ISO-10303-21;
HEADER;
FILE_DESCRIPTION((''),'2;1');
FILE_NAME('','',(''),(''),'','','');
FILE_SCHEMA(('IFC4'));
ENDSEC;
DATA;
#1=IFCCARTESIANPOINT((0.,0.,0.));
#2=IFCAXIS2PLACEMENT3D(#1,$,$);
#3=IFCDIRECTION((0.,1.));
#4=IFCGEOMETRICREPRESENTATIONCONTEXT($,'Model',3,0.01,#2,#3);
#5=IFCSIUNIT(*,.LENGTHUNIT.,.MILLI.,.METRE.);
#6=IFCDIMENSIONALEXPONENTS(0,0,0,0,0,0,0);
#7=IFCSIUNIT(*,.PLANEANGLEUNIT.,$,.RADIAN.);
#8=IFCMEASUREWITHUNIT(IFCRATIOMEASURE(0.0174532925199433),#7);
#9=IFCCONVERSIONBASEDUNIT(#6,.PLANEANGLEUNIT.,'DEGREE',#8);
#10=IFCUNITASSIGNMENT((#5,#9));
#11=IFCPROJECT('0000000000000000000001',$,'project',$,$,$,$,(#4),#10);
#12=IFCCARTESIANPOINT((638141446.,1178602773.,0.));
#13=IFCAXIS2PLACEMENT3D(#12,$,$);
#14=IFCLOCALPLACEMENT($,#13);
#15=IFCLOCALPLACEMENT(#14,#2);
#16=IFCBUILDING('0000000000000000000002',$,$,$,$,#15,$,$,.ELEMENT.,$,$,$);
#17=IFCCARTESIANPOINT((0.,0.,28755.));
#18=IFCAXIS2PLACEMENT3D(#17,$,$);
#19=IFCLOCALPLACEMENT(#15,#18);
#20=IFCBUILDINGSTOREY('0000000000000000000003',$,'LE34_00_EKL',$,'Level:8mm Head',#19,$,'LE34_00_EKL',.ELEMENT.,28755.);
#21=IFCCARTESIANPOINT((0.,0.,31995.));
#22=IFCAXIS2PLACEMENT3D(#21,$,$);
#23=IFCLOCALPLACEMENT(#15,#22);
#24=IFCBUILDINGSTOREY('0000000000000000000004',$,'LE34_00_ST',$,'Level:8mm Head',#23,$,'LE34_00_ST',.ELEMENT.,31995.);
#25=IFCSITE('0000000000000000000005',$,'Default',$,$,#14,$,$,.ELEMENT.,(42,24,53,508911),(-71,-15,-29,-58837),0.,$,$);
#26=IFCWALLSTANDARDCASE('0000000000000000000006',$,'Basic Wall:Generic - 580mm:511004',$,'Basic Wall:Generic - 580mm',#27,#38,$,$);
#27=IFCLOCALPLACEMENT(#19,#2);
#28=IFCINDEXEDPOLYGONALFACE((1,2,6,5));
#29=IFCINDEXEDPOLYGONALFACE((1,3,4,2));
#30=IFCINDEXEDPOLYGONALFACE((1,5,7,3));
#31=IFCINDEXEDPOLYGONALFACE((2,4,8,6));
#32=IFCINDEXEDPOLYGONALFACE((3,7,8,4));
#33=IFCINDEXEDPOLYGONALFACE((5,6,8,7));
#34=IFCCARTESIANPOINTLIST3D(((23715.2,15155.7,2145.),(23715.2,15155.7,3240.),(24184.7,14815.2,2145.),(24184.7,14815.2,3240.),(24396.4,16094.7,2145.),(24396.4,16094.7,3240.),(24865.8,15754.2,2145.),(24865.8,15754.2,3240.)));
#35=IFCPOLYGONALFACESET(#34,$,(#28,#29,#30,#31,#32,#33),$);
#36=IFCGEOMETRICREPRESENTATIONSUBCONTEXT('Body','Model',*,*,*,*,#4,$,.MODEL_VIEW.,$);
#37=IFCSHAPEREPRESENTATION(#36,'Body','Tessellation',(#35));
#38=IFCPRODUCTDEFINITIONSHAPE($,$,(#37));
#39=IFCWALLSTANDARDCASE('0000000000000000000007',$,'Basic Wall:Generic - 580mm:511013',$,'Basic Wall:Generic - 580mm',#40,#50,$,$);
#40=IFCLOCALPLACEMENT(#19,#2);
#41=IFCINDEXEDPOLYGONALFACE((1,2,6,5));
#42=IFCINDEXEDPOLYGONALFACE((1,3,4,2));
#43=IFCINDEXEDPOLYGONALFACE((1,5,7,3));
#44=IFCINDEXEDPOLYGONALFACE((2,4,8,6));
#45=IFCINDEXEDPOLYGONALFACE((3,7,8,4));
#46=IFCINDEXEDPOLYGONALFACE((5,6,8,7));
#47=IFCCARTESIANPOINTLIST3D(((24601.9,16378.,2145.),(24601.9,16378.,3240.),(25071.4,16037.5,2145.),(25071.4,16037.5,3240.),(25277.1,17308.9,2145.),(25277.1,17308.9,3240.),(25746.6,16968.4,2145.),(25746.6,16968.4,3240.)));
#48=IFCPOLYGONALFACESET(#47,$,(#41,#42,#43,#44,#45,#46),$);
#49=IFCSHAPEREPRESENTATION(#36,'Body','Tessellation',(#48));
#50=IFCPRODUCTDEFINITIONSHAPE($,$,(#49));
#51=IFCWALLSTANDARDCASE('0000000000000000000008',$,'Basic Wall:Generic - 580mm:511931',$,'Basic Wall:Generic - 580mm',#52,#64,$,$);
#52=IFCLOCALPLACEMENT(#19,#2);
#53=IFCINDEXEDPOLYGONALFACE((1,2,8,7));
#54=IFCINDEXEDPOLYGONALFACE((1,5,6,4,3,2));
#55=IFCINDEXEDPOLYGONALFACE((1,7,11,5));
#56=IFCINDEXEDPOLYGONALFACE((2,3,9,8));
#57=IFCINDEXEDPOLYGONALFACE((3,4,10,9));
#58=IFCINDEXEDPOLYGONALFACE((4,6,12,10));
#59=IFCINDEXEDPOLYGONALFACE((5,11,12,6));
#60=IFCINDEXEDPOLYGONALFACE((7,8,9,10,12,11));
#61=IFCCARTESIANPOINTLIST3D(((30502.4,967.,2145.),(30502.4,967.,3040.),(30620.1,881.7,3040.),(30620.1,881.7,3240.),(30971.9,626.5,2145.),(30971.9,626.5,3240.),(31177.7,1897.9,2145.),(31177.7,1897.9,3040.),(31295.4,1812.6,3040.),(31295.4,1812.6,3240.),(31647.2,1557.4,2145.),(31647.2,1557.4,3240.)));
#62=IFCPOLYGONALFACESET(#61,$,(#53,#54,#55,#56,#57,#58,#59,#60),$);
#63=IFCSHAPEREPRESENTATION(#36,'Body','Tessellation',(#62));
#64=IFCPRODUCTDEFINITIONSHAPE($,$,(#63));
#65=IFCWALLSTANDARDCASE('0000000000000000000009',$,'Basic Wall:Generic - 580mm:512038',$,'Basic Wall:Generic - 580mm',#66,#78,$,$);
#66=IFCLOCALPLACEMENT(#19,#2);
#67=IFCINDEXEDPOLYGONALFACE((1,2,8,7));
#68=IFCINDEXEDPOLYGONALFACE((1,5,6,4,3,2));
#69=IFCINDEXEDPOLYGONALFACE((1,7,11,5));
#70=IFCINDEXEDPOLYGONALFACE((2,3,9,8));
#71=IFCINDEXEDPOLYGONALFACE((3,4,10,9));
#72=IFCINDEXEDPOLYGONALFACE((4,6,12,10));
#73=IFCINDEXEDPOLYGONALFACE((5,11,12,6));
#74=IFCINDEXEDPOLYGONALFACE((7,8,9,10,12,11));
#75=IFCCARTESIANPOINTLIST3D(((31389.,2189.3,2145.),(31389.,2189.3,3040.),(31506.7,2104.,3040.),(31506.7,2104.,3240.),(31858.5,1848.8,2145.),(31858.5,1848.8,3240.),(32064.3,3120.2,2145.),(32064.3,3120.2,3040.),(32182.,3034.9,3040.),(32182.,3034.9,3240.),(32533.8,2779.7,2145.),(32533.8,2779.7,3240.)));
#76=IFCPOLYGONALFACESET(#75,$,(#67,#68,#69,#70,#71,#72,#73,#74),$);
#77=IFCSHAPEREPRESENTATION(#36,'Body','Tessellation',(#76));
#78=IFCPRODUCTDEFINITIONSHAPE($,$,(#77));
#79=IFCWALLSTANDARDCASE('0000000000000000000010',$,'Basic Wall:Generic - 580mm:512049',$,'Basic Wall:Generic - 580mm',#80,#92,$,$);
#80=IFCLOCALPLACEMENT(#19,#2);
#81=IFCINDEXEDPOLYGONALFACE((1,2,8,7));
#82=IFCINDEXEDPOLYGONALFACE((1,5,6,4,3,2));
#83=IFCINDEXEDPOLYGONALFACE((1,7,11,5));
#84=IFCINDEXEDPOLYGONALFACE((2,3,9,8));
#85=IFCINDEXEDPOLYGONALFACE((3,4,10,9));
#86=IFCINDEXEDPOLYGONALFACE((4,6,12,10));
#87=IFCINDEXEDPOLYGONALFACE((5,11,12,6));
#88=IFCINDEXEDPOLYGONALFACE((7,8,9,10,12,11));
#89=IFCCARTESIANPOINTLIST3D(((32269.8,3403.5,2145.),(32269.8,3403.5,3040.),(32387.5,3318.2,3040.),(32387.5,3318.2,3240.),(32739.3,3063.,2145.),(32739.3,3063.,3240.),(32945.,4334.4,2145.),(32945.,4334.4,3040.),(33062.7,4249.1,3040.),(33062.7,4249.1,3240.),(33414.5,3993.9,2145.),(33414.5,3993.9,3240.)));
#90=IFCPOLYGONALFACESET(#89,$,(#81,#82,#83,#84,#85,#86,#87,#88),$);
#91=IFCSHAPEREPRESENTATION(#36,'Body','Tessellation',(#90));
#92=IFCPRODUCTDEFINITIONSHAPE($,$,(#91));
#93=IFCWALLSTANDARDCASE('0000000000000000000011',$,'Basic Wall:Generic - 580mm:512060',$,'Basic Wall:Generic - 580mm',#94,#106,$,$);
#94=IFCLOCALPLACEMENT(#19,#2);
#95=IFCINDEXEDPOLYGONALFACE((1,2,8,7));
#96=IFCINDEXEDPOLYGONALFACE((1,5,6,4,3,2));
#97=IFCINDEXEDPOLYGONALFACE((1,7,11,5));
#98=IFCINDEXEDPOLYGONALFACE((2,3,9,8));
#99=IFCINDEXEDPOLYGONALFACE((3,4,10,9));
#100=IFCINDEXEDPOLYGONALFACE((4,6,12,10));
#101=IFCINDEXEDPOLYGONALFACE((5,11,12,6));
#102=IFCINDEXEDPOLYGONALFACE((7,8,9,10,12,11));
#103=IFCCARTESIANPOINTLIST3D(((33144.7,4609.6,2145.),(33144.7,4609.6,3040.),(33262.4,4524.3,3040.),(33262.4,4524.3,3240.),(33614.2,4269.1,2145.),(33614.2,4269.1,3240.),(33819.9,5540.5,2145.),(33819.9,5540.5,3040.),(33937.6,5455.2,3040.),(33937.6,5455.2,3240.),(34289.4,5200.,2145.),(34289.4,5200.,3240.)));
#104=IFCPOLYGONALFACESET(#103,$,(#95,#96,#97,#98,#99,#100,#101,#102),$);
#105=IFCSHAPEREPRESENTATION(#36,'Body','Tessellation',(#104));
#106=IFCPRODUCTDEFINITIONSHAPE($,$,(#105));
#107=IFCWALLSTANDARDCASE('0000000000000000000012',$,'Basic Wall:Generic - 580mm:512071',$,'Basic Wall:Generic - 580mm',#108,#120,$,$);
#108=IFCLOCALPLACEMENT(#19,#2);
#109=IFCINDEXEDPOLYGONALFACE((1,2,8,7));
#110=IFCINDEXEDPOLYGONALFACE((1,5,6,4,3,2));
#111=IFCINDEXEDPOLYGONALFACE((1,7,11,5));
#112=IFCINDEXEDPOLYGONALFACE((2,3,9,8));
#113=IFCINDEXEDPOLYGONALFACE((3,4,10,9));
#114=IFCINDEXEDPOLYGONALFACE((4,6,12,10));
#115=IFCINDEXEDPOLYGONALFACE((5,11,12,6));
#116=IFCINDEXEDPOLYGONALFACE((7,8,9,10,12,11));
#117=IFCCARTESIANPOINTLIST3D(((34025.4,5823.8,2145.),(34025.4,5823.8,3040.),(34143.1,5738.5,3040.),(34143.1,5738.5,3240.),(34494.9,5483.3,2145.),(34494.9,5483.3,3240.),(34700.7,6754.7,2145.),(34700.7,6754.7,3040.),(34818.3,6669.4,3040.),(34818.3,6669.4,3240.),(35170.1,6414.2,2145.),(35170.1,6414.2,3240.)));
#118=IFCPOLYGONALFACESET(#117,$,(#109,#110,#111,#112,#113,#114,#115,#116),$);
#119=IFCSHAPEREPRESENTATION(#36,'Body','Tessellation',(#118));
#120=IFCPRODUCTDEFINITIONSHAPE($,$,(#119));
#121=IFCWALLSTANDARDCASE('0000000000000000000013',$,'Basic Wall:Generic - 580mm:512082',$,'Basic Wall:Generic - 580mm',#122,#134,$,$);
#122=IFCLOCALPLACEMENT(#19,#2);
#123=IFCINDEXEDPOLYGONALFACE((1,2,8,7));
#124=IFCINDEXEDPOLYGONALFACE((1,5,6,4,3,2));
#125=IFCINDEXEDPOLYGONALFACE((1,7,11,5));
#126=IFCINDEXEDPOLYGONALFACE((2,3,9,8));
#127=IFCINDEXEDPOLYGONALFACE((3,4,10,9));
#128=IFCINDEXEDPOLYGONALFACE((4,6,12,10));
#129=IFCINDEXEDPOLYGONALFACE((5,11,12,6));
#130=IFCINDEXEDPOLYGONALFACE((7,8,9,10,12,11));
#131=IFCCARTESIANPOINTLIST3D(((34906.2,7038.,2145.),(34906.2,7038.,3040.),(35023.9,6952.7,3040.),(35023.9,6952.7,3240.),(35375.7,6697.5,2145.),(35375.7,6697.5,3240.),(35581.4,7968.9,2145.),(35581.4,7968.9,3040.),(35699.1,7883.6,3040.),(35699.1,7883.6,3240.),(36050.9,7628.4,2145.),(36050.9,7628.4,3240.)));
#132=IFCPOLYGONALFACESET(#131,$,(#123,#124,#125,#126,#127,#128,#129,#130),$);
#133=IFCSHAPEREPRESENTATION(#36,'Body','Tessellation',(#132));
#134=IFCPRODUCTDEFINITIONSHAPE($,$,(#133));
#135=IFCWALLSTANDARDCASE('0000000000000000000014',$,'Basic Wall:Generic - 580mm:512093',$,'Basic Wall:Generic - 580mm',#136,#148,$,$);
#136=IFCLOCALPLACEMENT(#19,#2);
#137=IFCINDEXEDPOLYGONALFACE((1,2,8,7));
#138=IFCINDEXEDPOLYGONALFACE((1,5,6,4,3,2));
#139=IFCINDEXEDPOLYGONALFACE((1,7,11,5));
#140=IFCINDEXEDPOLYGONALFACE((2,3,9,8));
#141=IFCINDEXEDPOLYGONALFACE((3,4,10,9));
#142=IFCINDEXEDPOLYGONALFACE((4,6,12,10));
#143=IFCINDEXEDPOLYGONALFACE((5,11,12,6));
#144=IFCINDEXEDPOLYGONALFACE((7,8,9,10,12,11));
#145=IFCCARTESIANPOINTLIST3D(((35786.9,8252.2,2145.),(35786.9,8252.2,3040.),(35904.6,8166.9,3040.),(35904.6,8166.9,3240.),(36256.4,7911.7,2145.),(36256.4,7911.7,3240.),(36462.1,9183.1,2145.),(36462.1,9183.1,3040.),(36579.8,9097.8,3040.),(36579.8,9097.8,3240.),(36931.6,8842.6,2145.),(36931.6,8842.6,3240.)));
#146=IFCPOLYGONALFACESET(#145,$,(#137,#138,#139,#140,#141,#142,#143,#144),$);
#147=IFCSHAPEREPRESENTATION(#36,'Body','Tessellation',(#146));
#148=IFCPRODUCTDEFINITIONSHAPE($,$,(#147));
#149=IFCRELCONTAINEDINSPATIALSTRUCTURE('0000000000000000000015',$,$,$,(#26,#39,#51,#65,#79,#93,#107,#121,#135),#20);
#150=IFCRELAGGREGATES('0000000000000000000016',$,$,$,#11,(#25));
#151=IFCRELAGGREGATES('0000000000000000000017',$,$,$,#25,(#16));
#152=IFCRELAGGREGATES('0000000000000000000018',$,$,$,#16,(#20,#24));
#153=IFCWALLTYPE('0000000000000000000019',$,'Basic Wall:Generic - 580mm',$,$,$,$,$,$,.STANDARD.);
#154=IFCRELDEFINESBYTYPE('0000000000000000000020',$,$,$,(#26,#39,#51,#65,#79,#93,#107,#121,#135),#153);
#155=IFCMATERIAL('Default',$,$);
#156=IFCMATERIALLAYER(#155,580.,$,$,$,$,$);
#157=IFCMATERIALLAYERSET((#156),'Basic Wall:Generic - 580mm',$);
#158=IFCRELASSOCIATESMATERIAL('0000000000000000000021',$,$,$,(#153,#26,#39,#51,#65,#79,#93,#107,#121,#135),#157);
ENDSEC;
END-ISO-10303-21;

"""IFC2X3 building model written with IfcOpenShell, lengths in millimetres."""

from ifc_helpers import new_model, entity, si_unit, converted_unit, direction, frame, frame_2d, origin, place, context, subcontext, project, spatial, polyline, rectangle, extrude, clip, bounded_halfspace, material, layer, layer_set, layer_usage, type_object, element, save


model = new_model("IFC2X3")

# Units and contexts
model_context = context("Model", 3, precision=0.01, world=origin(), true_north=direction((0.0, 1.0)))
body_context = subcontext(model_context, "Body", "Model", "MODEL_VIEW")
ifc_project = project(units=[si_unit("LENGTHUNIT", "METRE", prefix="MILLI"), converted_unit("PLANEANGLEUNIT", "DEGREE", entity("IfcRatioMeasure", 0.0174532925199433), si_unit("PLANEANGLEUNIT", "RADIAN"), dimensions=[0, 0, 0, 0, 0, 0, 0])], contexts=[model_context])

# Site, building, storey
site_placement = place(None, frame((638141446.0, 1178602773.0, 0.0)))
site = spatial("IfcSite", under=ifc_project, at=site_placement, Name="Default", CompositionType="ELEMENT", RefLatitude=(42, 24, 53, 508911), RefLongitude=(-71, -15, -29, -58837), RefElevation=0.0)
building_placement = place(site_placement, origin())
building = spatial("IfcBuilding", under=site, at=building_placement, CompositionType="ELEMENT")
storey_1_placement = place(building_placement, frame((0.0, 0.0, 28755.0)))
storey_1 = spatial("IfcBuildingStorey", under=building, at=storey_1_placement, Name="LE34_00_EKL", ObjectType="Level:8mm Head", LongName="LE34_00_EKL", CompositionType="ELEMENT", Elevation=28755.0)

# Shared definitions
ifc_material_1 = material(Name="Default")

# Shared definitions
storey_2_placement = place(building_placement, frame((0.0, 0.0, 31995.0)))
storey_2 = spatial("IfcBuildingStorey", under=building, at=storey_2_placement, Name="LE34_00_ST", ObjectType="Level:8mm Head", LongName="LE34_00_ST", CompositionType="ELEMENT", Elevation=31995.0)

# Walls
ifc_layer_1 = layer(ifc_material_1, 580.0)
ifc_layer_set_1 = layer_set([ifc_layer_1], Name="Basic Wall:Generic - 580mm")
wall_type_1 = type_object("IfcWallType", Name="Basic Wall:Generic - 580mm", PredefinedType="STANDARD", material=ifc_layer_set_1)
ifc_layer_usage_1 = layer_usage(ifc_layer_set_1, "AXIS2", "NEGATIVE", 290.0)
wall_1_placement = place(storey_1_placement, frame((23950.0, 14985.5, 2145.0), z_axis=(0.0, 0.0, 1.0), x_axis=(0.587164, 0.809468, 0.0)))
element("IfcWallStandardCase", 1, at=wall_1_placement, inside=storey_1, type_object=wall_type_1, material=ifc_layer_usage_1, Name="Basic Wall:Generic - 580mm:511004", ObjectType="Basic Wall:Generic - 580mm", context=body_context, shape_type="SweptSolid", body=[
    extrude(rectangle(XDim=1160.0, YDim=580.0, at=frame_2d((580.0, 0.0), x_axis=(-1.0, 0.0))), origin(), (0.0, 0.0, 1.0), 1095.0),
])
ifc_layer_usage_2 = layer_usage(ifc_layer_set_1, "AXIS2", "NEGATIVE", 290.0)
wall_2_placement = place(storey_1_placement, frame((24836.6, 16207.8, 2145.0), z_axis=(0.0, 0.0, 1.0), x_axis=(0.587164, 0.809468, 0.0)))
element("IfcWallStandardCase", 2, at=wall_2_placement, inside=storey_1, type_object=wall_type_1, material=ifc_layer_usage_2, Name="Basic Wall:Generic - 580mm:511013", ObjectType="Basic Wall:Generic - 580mm", context=body_context, shape_type="SweptSolid", body=[
    extrude(rectangle(XDim=1150.0, YDim=580.0, at=frame_2d((575.0, 0.0), x_axis=(-1.0, 0.0))), origin(), (0.0, 0.0, 1.0), 1095.0),
])
ifc_layer_usage_3 = layer_usage(ifc_layer_set_1, "AXIS2", "NEGATIVE", 290.0)
wall_3_placement = place(storey_1_placement, frame((30737.2, 796.8, 2145.0), z_axis=(0.0, 0.0, 1.0), x_axis=(0.587164, 0.809468, 0.0)))
element("IfcWallStandardCase", 3, at=wall_3_placement, inside=storey_1, type_object=wall_type_1, material=ifc_layer_usage_3, Name="Basic Wall:Generic - 580mm:511931", ObjectType="Basic Wall:Generic - 580mm", context=body_context, shape_type="Clipping", body=[
    clip(clip(extrude(rectangle(XDim=1150.0, YDim=580.0, at=frame_2d((575.0, 0.0), x_axis=(-1.0, 0.0))), origin(), (0.0, 0.0, 1.0), 1095.0), bounded_halfspace(frame((0.0, 144.6, 895.0), z_axis=(0.0, 0.0, -1.0), x_axis=(0.0, 1.0, 0.0)), True, frame((0.0, 144.6, 895.0), z_axis=(0.0, 0.0, -1.0), x_axis=(0.0, 1.0, 0.0)), polyline([(0.0, 0.0), (145.4, 0.0), (145.4, 1150.0), (0.0, 1150.0), (0.0, 0.0)]))), bounded_halfspace(frame((1150.0, 144.6, 895.0), z_axis=(0.0, -1.0, 0.0), x_axis=(0.0, 0.0, 1.0)), True, frame((1150.0, 144.6, 895.0), z_axis=(0.0, -1.0, 0.0), x_axis=(0.0, 0.0, 1.0)), polyline([(0.0, 0.0), (200.0, 0.0), (200.0, 1150.0), (0.0, 1150.0), (0.0, 0.0)]))),
])
ifc_layer_usage_4 = layer_usage(ifc_layer_set_1, "AXIS2", "NEGATIVE", 290.0)
wall_4_placement = place(storey_1_placement, frame((31623.8, 2019.1, 2145.0), z_axis=(0.0, 0.0, 1.0), x_axis=(0.587164, 0.809468, 0.0)))
element("IfcWallStandardCase", 4, at=wall_4_placement, inside=storey_1, type_object=wall_type_1, material=ifc_layer_usage_4, Name="Basic Wall:Generic - 580mm:512038", ObjectType="Basic Wall:Generic - 580mm", context=body_context, shape_type="Clipping", body=[
    clip(clip(extrude(rectangle(XDim=1150.0, YDim=580.0, at=frame_2d((575.0, 0.0), x_axis=(-1.0, 0.0))), origin(), (0.0, 0.0, 1.0), 1095.0), bounded_halfspace(frame((0.0, 144.6, 895.0), z_axis=(0.0, 0.0, -1.0), x_axis=(0.0, 1.0, 0.0)), True, frame((0.0, 144.6, 895.0), z_axis=(0.0, 0.0, -1.0), x_axis=(0.0, 1.0, 0.0)), polyline([(0.0, 0.0), (145.4, 0.0), (145.4, 1150.0), (0.0, 1150.0), (0.0, 0.0)]))), bounded_halfspace(frame((1150.0, 144.6, 895.0), z_axis=(0.0, -1.0, 0.0), x_axis=(0.0, 0.0, 1.0)), True, frame((1150.0, 144.6, 895.0), z_axis=(0.0, -1.0, 0.0), x_axis=(0.0, 0.0, 1.0)), polyline([(0.0, 0.0), (200.0, 0.0), (200.0, 1150.0), (0.0, 1150.0), (0.0, 0.0)]))),
])
ifc_layer_usage_5 = layer_usage(ifc_layer_set_1, "AXIS2", "NEGATIVE", 290.0)
wall_5_placement = place(storey_1_placement, frame((32504.5, 3233.3, 2145.0), z_axis=(0.0, 0.0, 1.0), x_axis=(0.587164, 0.809468, 0.0)))
element("IfcWallStandardCase", 5, at=wall_5_placement, inside=storey_1, type_object=wall_type_1, material=ifc_layer_usage_5, Name="Basic Wall:Generic - 580mm:512049", ObjectType="Basic Wall:Generic - 580mm", context=body_context, shape_type="Clipping", body=[
    clip(clip(extrude(rectangle(XDim=1150.0, YDim=580.0, at=frame_2d((575.0, 0.0), x_axis=(-1.0, 0.0))), origin(), (0.0, 0.0, 1.0), 1095.0), bounded_halfspace(frame((0.0, 144.6, 895.0), z_axis=(0.0, 0.0, -1.0), x_axis=(0.0, 1.0, 0.0)), True, frame((0.0, 144.6, 895.0), z_axis=(0.0, 0.0, -1.0), x_axis=(0.0, 1.0, 0.0)), polyline([(0.0, 0.0), (145.4, 0.0), (145.4, 1150.0), (0.0, 1150.0), (0.0, 0.0)]))), bounded_halfspace(frame((1150.0, 144.6, 895.0), z_axis=(0.0, -1.0, 0.0), x_axis=(0.0, 0.0, 1.0)), True, frame((1150.0, 144.6, 895.0), z_axis=(0.0, -1.0, 0.0), x_axis=(0.0, 0.0, 1.0)), polyline([(0.0, 0.0), (200.0, 0.0), (200.0, 1150.0), (0.0, 1150.0), (0.0, 0.0)]))),
])
ifc_layer_usage_6 = layer_usage(ifc_layer_set_1, "AXIS2", "NEGATIVE", 290.0)
wall_6_placement = place(storey_1_placement, frame((33379.4, 4439.4, 2145.0), z_axis=(0.0, 0.0, 1.0), x_axis=(0.587164, 0.809468, 0.0)))
element("IfcWallStandardCase", 6, at=wall_6_placement, inside=storey_1, type_object=wall_type_1, material=ifc_layer_usage_6, Name="Basic Wall:Generic - 580mm:512060", ObjectType="Basic Wall:Generic - 580mm", context=body_context, shape_type="Clipping", body=[
    clip(clip(extrude(rectangle(XDim=1150.0, YDim=580.0, at=frame_2d((575.0, 0.0), x_axis=(-1.0, 0.0))), origin(), (0.0, 0.0, 1.0), 1095.0), bounded_halfspace(frame((0.0, 144.6, 895.0), z_axis=(0.0, 0.0, -1.0), x_axis=(0.0, 1.0, 0.0)), True, frame((0.0, 144.6, 895.0), z_axis=(0.0, 0.0, -1.0), x_axis=(0.0, 1.0, 0.0)), polyline([(0.0, 0.0), (145.4, 0.0), (145.4, 1150.0), (0.0, 1150.0), (0.0, 0.0)]))), bounded_halfspace(frame((1150.0, 144.6, 895.0), z_axis=(0.0, -1.0, 0.0), x_axis=(0.0, 0.0, 1.0)), True, frame((1150.0, 144.6, 895.0), z_axis=(0.0, -1.0, 0.0), x_axis=(0.0, 0.0, 1.0)), polyline([(0.0, 0.0), (200.0, 0.0), (200.0, 1150.0), (0.0, 1150.0), (0.0, 0.0)]))),
])
ifc_layer_usage_7 = layer_usage(ifc_layer_set_1, "AXIS2", "NEGATIVE", 290.0)
wall_7_placement = place(storey_1_placement, frame((34260.2, 5653.6, 2145.0), z_axis=(0.0, 0.0, 1.0), x_axis=(0.587164, 0.809468, 0.0)))
element("IfcWallStandardCase", 7, at=wall_7_placement, inside=storey_1, type_object=wall_type_1, material=ifc_layer_usage_7, Name="Basic Wall:Generic - 580mm:512071", ObjectType="Basic Wall:Generic - 580mm", context=body_context, shape_type="Clipping", body=[
    clip(clip(extrude(rectangle(XDim=1150.0, YDim=580.0, at=frame_2d((575.0, 0.0), x_axis=(-1.0, 0.0))), origin(), (0.0, 0.0, 1.0), 1095.0), bounded_halfspace(frame((0.0, 144.6, 895.0), z_axis=(0.0, 0.0, -1.0), x_axis=(0.0, 1.0, 0.0)), True, frame((0.0, 144.6, 895.0), z_axis=(0.0, 0.0, -1.0), x_axis=(0.0, 1.0, 0.0)), polyline([(0.0, 0.0), (145.4, 0.0), (145.4, 1150.0), (0.0, 1150.0), (0.0, 0.0)]))), bounded_halfspace(frame((1150.0, 144.6, 895.0), z_axis=(0.0, -1.0, 0.0), x_axis=(0.0, 0.0, 1.0)), True, frame((1150.0, 144.6, 895.0), z_axis=(0.0, -1.0, 0.0), x_axis=(0.0, 0.0, 1.0)), polyline([(0.0, 0.0), (200.0, 0.0), (200.0, 1150.0), (0.0, 1150.0), (0.0, 0.0)]))),
])
ifc_layer_usage_8 = layer_usage(ifc_layer_set_1, "AXIS2", "NEGATIVE", 290.0)
wall_8_placement = place(storey_1_placement, frame((35140.9, 6867.8, 2145.0), z_axis=(0.0, 0.0, 1.0), x_axis=(0.587164, 0.809468, 0.0)))
element("IfcWallStandardCase", 8, at=wall_8_placement, inside=storey_1, type_object=wall_type_1, material=ifc_layer_usage_8, Name="Basic Wall:Generic - 580mm:512082", ObjectType="Basic Wall:Generic - 580mm", context=body_context, shape_type="Clipping", body=[
    clip(clip(extrude(rectangle(XDim=1150.0, YDim=580.0, at=frame_2d((575.0, 0.0), x_axis=(-1.0, 0.0))), origin(), (0.0, 0.0, 1.0), 1095.0), bounded_halfspace(frame((0.0, 144.6, 895.0), z_axis=(0.0, 0.0, -1.0), x_axis=(0.0, 1.0, 0.0)), True, frame((0.0, 144.6, 895.0), z_axis=(0.0, 0.0, -1.0), x_axis=(0.0, 1.0, 0.0)), polyline([(0.0, 0.0), (145.4, 0.0), (145.4, 1150.0), (0.0, 1150.0), (0.0, 0.0)]))), bounded_halfspace(frame((1150.0, 144.6, 895.0), z_axis=(0.0, -1.0, 0.0), x_axis=(0.0, 0.0, 1.0)), True, frame((1150.0, 144.6, 895.0), z_axis=(0.0, -1.0, 0.0), x_axis=(0.0, 0.0, 1.0)), polyline([(0.0, 0.0), (200.0, 0.0), (200.0, 1150.0), (0.0, 1150.0), (0.0, 0.0)]))),
])
ifc_layer_usage_9 = layer_usage(ifc_layer_set_1, "AXIS2", "NEGATIVE", 290.0)
wall_9_placement = place(storey_1_placement, frame((36021.7, 8082.0, 2145.0), z_axis=(0.0, 0.0, 1.0), x_axis=(0.587164, 0.809468, 0.0)))
element("IfcWallStandardCase", 9, at=wall_9_placement, inside=storey_1, type_object=wall_type_1, material=ifc_layer_usage_9, Name="Basic Wall:Generic - 580mm:512093", ObjectType="Basic Wall:Generic - 580mm", context=body_context, shape_type="Clipping", body=[
    clip(clip(extrude(rectangle(XDim=1150.0, YDim=580.0, at=frame_2d((575.0, 0.0), x_axis=(-1.0, 0.0))), origin(), (0.0, 0.0, 1.0), 1095.0), bounded_halfspace(frame((0.0, 144.6, 895.0), z_axis=(0.0, 0.0, -1.0), x_axis=(0.0, 1.0, 0.0)), True, frame((0.0, 144.6, 895.0), z_axis=(0.0, 0.0, -1.0), x_axis=(0.0, 1.0, 0.0)), polyline([(0.0, 0.0), (145.4, 0.0), (145.4, 1150.0), (0.0, 1150.0), (0.0, 0.0)]))), bounded_halfspace(frame((1150.0, 144.6, 895.0), z_axis=(0.0, -1.0, 0.0), x_axis=(0.0, 0.0, 1.0)), True, frame((1150.0, 144.6, 895.0), z_axis=(0.0, -1.0, 0.0), x_axis=(0.0, 0.0, 1.0)), polyline([(0.0, 0.0), (200.0, 0.0), (200.0, 1150.0), (0.0, 1150.0), (0.0, 0.0)]))),
])

save(model, "model.ifc")
